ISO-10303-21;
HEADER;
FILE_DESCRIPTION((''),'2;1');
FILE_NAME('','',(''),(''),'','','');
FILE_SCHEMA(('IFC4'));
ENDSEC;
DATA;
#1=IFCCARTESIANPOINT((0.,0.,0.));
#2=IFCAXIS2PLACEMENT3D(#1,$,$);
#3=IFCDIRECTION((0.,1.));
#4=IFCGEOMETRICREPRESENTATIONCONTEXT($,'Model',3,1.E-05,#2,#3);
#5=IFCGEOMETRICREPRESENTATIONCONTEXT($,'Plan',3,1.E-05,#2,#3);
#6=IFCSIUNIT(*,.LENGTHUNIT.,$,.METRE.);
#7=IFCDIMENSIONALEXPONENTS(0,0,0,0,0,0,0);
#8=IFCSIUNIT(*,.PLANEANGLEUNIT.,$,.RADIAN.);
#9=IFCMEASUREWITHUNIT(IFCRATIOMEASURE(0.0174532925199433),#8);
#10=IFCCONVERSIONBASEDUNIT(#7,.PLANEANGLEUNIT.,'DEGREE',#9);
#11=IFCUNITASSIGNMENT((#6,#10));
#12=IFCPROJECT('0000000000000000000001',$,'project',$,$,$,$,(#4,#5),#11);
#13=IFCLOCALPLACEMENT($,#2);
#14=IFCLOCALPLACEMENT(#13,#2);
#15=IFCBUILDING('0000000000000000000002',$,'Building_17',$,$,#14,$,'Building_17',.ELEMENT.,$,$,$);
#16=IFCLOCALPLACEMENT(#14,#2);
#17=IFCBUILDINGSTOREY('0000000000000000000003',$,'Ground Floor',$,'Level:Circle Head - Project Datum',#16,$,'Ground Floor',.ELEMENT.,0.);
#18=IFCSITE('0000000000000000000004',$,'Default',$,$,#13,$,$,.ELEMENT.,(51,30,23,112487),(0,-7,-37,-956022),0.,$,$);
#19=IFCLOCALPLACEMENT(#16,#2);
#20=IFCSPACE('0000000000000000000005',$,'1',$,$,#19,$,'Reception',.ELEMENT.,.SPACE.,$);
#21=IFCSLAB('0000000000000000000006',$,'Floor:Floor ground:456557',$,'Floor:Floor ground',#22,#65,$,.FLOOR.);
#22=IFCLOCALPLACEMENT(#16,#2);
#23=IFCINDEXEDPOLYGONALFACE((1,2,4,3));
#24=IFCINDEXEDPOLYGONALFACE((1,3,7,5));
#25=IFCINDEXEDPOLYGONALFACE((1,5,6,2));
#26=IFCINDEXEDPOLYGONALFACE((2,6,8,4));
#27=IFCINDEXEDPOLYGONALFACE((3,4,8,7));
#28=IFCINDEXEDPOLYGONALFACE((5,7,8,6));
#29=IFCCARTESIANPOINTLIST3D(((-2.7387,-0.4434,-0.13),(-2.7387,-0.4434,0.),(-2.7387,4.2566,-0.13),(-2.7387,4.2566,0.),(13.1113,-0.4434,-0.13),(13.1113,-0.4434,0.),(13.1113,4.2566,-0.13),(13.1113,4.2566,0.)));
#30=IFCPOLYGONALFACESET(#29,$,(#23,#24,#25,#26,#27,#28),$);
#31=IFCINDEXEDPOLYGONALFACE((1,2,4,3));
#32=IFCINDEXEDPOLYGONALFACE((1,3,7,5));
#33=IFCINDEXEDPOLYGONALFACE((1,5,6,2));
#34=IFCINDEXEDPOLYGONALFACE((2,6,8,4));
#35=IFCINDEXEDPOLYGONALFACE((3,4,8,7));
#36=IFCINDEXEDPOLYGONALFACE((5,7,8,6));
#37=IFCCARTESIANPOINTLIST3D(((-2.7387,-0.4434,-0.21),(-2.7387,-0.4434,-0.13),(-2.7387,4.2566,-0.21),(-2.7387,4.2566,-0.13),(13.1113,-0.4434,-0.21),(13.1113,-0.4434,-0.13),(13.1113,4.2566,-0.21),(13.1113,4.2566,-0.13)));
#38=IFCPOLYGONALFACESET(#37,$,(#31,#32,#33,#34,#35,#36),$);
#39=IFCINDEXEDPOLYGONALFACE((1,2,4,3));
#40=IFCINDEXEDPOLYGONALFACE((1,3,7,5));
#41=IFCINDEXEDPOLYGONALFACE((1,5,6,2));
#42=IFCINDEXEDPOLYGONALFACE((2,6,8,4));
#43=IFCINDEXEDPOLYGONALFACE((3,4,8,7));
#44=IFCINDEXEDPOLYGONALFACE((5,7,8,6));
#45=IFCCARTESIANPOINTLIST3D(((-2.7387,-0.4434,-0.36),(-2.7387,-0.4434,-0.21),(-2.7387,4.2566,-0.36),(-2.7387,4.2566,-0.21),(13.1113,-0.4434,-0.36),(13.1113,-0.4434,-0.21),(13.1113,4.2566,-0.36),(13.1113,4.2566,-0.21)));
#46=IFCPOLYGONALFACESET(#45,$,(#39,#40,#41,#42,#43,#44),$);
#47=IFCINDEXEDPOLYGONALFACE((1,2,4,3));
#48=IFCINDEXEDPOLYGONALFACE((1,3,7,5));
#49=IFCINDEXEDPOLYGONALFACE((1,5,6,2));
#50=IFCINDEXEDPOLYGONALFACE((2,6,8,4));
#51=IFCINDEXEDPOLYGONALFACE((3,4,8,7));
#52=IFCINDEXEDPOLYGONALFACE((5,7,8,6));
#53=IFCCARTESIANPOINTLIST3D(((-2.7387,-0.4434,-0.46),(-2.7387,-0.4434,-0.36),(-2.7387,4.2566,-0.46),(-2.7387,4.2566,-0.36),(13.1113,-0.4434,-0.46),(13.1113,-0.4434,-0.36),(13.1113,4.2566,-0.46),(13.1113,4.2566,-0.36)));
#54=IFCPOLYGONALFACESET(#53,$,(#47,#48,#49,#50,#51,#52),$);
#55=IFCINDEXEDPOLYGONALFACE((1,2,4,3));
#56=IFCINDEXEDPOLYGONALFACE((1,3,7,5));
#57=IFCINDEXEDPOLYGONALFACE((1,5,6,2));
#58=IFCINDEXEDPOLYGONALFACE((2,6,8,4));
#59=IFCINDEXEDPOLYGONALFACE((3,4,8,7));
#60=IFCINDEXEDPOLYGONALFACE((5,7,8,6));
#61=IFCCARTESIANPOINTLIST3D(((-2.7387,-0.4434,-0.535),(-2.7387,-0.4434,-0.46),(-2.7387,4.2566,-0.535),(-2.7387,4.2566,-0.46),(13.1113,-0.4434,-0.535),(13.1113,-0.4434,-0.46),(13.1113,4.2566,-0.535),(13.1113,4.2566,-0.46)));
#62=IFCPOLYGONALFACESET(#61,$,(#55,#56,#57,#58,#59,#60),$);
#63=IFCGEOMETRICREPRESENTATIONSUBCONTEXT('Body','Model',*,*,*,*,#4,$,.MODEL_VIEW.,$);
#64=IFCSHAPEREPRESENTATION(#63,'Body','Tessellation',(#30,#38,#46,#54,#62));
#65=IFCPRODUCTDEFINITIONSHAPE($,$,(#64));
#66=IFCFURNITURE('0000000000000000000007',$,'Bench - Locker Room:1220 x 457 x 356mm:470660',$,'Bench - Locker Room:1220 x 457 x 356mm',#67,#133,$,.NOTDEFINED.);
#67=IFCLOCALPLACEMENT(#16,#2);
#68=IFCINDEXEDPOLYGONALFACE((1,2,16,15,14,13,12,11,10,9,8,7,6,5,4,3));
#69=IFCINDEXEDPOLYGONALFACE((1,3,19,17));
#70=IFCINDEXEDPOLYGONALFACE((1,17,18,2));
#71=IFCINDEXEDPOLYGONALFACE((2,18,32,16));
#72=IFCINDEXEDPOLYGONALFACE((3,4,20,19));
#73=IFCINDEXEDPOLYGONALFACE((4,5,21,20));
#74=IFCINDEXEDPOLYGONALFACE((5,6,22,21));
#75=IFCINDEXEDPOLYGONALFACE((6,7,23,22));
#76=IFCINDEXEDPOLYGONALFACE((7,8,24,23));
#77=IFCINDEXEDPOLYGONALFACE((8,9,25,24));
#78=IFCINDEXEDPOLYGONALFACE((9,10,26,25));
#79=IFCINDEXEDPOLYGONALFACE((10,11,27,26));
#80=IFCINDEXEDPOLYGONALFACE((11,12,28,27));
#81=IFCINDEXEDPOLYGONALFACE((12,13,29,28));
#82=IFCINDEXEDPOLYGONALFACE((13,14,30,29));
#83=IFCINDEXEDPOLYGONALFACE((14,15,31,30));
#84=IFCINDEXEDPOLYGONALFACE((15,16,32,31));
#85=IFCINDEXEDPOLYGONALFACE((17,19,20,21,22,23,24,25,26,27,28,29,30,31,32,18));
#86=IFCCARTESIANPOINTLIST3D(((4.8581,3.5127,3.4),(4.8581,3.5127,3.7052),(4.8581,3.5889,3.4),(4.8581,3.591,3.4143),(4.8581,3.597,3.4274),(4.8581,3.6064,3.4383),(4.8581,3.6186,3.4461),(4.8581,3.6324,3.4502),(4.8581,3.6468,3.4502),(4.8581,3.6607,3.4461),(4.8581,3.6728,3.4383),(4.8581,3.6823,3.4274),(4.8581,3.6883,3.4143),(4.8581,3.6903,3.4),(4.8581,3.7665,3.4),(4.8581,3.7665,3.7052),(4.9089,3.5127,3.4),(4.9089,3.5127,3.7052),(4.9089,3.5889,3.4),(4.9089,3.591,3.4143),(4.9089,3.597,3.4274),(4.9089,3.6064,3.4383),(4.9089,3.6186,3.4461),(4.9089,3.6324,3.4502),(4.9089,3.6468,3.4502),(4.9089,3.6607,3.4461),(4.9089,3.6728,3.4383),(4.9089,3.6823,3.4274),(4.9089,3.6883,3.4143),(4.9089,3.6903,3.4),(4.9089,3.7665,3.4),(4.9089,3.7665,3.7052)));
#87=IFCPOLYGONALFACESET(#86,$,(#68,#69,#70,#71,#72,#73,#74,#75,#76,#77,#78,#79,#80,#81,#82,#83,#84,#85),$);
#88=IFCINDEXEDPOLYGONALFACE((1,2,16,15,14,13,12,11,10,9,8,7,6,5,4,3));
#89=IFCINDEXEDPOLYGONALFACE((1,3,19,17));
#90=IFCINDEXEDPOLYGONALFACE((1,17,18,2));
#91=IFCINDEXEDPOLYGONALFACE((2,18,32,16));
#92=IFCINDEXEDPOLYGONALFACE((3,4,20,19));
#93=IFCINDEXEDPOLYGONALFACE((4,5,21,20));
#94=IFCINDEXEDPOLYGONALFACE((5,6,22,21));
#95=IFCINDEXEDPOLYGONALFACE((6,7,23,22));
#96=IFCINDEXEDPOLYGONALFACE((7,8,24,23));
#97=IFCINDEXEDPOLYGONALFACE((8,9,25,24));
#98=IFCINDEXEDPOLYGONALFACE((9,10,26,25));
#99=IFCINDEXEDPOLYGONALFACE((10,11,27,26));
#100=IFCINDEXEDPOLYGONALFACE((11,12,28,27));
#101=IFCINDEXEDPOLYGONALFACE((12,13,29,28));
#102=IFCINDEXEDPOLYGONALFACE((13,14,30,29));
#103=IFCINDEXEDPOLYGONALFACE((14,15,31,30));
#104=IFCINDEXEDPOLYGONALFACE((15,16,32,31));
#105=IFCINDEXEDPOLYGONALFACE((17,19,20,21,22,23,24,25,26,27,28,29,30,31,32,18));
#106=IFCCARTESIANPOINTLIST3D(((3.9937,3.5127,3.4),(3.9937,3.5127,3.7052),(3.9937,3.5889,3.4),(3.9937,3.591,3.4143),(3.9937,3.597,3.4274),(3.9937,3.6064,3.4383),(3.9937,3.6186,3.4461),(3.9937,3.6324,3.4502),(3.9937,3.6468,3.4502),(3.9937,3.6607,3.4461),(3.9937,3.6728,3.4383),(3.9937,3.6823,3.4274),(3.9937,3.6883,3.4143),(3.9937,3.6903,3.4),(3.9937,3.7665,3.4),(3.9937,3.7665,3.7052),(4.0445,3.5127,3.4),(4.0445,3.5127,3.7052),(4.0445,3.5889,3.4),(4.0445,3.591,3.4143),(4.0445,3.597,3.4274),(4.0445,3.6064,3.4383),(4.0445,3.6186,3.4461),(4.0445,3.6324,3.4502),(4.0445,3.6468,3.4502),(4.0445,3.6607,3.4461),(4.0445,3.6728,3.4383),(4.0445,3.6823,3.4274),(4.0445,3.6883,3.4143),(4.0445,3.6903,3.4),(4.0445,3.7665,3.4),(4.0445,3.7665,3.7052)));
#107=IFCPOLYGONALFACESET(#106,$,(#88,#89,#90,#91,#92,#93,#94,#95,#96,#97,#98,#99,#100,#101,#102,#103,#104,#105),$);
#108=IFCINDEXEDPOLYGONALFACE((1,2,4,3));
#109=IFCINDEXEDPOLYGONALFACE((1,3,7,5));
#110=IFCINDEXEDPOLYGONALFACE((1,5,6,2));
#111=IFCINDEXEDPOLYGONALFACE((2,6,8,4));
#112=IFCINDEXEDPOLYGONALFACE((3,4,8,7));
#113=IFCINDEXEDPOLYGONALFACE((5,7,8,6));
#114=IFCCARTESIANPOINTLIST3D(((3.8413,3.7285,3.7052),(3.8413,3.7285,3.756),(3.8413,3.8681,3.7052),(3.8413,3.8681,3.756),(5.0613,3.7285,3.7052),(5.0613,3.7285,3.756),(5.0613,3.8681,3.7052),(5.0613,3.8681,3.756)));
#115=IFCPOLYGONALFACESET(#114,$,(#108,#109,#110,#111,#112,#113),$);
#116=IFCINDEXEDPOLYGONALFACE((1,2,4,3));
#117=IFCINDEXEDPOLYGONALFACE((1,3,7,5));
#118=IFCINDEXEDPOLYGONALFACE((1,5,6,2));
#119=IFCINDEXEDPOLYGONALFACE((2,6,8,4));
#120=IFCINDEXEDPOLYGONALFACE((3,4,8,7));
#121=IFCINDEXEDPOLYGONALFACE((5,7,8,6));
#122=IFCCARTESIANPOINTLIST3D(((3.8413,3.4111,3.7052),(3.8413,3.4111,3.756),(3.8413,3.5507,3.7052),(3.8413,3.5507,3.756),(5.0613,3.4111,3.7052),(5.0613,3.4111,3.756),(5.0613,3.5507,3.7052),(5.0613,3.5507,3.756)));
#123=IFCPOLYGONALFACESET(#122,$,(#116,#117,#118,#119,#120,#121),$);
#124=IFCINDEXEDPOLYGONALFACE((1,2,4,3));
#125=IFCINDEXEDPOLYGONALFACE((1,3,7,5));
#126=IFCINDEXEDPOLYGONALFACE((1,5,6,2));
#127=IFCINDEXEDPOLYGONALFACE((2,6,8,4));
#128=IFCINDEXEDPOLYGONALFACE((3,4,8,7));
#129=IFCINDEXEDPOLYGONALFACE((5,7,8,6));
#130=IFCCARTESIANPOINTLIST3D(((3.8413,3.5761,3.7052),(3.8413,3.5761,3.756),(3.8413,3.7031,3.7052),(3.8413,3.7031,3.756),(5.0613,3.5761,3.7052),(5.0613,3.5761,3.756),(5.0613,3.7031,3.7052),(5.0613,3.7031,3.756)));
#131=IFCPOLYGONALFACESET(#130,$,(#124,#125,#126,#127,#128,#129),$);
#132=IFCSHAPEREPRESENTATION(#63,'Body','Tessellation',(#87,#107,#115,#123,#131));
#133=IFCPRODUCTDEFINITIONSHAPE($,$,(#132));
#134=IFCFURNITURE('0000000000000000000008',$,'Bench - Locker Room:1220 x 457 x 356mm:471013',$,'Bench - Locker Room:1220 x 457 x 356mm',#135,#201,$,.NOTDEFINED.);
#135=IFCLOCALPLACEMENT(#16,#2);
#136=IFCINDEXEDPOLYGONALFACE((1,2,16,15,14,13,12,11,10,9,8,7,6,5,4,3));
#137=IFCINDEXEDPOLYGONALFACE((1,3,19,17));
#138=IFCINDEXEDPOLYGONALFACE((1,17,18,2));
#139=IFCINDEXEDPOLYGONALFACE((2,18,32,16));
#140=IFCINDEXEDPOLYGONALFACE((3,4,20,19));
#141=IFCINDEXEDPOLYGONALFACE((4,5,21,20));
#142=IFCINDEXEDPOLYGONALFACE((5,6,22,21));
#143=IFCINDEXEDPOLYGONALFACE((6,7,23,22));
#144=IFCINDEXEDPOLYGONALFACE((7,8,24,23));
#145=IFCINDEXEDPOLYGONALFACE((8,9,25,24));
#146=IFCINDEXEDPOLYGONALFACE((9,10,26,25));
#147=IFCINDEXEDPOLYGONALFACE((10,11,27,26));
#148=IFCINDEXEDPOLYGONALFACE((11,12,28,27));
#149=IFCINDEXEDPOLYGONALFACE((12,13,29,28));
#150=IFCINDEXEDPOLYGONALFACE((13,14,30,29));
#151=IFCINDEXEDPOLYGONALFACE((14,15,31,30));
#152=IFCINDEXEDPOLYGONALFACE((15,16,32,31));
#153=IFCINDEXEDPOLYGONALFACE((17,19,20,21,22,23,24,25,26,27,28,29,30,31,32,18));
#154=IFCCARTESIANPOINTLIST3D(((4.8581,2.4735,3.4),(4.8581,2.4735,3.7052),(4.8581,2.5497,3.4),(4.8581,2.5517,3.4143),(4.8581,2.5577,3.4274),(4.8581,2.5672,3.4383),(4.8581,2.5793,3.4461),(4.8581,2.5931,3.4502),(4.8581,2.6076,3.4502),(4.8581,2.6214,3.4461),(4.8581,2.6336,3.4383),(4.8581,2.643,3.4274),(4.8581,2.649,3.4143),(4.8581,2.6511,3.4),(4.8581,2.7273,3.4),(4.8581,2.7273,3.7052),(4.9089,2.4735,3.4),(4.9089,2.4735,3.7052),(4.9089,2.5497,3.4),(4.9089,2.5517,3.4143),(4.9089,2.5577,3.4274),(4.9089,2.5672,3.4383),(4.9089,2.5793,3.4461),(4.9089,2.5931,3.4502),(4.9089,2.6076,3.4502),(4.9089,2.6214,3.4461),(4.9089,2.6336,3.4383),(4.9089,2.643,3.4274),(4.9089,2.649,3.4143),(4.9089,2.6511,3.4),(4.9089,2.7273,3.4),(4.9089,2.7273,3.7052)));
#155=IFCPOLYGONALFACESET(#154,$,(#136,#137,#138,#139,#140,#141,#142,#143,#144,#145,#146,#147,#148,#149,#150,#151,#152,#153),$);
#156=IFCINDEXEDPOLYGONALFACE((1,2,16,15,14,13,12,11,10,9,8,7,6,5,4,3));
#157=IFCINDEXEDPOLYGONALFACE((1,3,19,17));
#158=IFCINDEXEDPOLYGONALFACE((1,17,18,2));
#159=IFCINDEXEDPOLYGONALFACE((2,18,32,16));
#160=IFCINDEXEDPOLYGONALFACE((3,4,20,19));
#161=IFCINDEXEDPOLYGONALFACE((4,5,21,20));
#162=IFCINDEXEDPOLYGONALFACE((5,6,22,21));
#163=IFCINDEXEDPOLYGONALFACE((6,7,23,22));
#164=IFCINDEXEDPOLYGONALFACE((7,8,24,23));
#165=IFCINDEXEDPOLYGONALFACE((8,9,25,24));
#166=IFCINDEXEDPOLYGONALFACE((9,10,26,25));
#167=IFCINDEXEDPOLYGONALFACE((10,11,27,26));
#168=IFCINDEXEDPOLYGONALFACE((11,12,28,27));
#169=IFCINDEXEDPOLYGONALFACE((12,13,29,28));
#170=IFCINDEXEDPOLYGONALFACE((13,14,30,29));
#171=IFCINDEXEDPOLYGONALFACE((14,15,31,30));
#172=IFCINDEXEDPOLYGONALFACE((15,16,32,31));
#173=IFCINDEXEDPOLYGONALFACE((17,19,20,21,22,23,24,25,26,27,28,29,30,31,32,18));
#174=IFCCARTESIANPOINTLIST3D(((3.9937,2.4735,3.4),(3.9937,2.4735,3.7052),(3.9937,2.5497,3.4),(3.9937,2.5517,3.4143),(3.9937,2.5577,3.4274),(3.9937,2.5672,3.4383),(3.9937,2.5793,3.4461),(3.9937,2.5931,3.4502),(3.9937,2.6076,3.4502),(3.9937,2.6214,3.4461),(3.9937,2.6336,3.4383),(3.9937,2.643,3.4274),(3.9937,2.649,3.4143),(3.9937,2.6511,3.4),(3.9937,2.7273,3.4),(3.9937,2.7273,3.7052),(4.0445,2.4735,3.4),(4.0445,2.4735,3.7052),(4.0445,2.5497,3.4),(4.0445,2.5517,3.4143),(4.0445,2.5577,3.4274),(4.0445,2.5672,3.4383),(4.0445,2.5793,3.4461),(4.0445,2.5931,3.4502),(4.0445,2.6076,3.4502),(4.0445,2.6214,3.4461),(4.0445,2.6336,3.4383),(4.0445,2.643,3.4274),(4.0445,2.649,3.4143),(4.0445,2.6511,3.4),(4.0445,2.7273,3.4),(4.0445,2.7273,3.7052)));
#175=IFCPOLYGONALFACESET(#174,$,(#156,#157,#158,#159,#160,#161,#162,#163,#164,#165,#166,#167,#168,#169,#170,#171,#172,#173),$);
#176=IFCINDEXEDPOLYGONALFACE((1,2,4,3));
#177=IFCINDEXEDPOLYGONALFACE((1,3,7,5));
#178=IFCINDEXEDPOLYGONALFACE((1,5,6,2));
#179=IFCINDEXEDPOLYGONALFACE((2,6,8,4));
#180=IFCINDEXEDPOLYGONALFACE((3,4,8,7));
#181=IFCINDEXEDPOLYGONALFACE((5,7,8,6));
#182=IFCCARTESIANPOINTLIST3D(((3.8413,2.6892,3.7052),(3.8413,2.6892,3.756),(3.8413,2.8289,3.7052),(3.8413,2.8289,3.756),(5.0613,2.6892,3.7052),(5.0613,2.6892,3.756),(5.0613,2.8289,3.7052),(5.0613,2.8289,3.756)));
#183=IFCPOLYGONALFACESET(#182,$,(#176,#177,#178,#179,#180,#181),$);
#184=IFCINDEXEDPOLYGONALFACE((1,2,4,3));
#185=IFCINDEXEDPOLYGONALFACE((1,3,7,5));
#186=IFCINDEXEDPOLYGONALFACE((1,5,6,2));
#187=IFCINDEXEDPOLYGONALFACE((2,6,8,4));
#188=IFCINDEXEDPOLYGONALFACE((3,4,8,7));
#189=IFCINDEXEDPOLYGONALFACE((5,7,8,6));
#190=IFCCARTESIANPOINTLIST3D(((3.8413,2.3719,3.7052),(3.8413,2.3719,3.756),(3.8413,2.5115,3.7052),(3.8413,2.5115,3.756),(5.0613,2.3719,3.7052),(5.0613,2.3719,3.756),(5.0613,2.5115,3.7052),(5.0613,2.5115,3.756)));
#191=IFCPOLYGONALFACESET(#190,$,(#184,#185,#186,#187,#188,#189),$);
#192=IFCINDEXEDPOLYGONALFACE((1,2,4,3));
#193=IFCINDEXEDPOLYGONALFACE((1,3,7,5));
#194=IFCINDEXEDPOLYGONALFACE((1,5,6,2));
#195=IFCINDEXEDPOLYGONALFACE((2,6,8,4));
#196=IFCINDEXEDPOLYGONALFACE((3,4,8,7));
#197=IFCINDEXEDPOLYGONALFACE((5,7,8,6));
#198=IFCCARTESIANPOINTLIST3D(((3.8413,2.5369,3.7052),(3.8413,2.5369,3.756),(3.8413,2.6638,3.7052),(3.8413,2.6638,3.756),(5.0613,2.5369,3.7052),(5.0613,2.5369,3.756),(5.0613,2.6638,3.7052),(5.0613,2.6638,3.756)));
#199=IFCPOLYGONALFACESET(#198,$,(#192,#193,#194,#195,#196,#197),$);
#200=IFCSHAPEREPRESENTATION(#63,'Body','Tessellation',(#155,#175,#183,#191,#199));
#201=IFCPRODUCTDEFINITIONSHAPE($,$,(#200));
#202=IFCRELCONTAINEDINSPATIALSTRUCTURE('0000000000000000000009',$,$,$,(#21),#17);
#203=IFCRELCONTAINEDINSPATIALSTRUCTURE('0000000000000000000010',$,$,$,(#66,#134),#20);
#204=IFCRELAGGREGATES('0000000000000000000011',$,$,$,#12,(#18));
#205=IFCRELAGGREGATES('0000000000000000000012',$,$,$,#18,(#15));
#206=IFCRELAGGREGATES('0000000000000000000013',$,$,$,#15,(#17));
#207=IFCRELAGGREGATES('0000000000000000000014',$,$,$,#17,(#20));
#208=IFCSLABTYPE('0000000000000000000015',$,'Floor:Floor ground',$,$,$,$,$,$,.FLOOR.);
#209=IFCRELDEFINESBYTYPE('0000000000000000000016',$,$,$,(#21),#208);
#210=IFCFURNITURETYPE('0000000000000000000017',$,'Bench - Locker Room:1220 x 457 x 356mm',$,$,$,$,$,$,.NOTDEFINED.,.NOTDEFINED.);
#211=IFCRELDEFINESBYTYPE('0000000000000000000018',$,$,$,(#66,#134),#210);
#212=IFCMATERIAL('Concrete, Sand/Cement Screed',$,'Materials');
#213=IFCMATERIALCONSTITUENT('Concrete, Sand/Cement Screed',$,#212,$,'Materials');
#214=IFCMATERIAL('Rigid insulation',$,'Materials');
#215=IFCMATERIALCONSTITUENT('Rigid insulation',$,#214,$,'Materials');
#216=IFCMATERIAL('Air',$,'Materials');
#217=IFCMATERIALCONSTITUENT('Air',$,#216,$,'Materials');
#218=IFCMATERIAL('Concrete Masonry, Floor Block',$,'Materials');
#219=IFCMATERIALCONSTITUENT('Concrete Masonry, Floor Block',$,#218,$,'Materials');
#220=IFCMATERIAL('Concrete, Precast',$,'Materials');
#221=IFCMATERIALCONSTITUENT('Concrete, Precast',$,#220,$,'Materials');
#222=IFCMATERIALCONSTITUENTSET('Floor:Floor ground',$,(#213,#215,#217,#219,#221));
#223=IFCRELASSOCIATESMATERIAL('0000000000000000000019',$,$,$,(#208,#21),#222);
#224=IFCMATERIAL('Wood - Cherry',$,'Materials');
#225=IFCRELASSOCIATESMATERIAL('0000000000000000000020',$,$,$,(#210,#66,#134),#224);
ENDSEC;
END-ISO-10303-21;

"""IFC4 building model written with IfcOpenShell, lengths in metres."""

from ifc_helpers import new_model, entity, si_unit, converted_unit, direction, frame, origin, place, context, subcontext, project, spatial, line, arc, indexed_curve, outline, extrude, source, transform, mapped, material, constituent, constituent_set, type_object, type_shapes, element, save


model = new_model("IFC4")

# Units and contexts
model_context = context("Model", 3, precision=1e-05, world=origin(), true_north=direction((0.0, 1.0)))
plan_context = context("Plan", 3, precision=1e-05, world=origin(), true_north=direction((0.0, 1.0)))
body_context = subcontext(model_context, "Body", "Model", "MODEL_VIEW")
ifc_project = project(units=[si_unit("LENGTHUNIT", "METRE"), converted_unit("PLANEANGLEUNIT", "DEGREE", entity("IfcRatioMeasure", 0.0174532925199433), si_unit("PLANEANGLEUNIT", "RADIAN"), dimensions=[0, 0, 0, 0, 0, 0, 0])], contexts=[model_context, plan_context])

# Site, building, storey
site_placement = place(None, origin())
site = spatial("IfcSite", under=ifc_project, at=site_placement, Name="Default", CompositionType="ELEMENT", RefLatitude=(51, 30, 23, 112487), RefLongitude=(0, -7, -37, -956022), RefElevation=0.0)
building_placement = place(site_placement, origin())
building = spatial("IfcBuilding", under=site, at=building_placement, Name="Building_17", LongName="Building_17", CompositionType="ELEMENT")
storey_placement = place(building_placement, origin())
storey = spatial("IfcBuildingStorey", under=building, at=storey_placement, Name="Ground Floor", ObjectType="Level:Circle Head - Project Datum", LongName="Ground Floor", CompositionType="ELEMENT", Elevation=0.0)

# Slab
ifc_material_1 = material(Name="Concrete, Sand/Cement Screed", Category="Materials")
ifc_constituent_1 = constituent(ifc_material_1, Name="Concrete, Sand/Cement Screed", Category="Materials")
ifc_material_2 = material(Name="Rigid insulation", Category="Materials")
ifc_constituent_2 = constituent(ifc_material_2, Name="Rigid insulation", Category="Materials")
ifc_material_3 = material(Name="Air", Category="Materials")
ifc_constituent_3 = constituent(ifc_material_3, Name="Air", Category="Materials")
ifc_material_4 = material(Name="Concrete Masonry, Floor Block", Category="Materials")
ifc_constituent_4 = constituent(ifc_material_4, Name="Concrete Masonry, Floor Block", Category="Materials")
ifc_material_5 = material(Name="Concrete, Precast", Category="Materials")
ifc_constituent_5 = constituent(ifc_material_5, Name="Concrete, Precast", Category="Materials")
ifc_constituent_set = constituent_set(constituents=[ifc_constituent_1, ifc_constituent_2, ifc_constituent_3, ifc_constituent_4, ifc_constituent_5], Name="Floor:Floor ground")
slab_type = type_object("IfcSlabType", Name="Floor:Floor ground", PredefinedType="FLOOR", material=ifc_constituent_set)
slab_placement = place(storey_placement, origin())
element("IfcSlab", 1, at=slab_placement, inside=storey, type_object=slab_type, material=ifc_constituent_set, Name="Floor:Floor ground:456557", ObjectType="Floor:Floor ground", PredefinedType="FLOOR", context=body_context, shape_type="SweptSolid", body=[
    extrude(outline(indexed_curve([(-7.925, -2.35), (7.925, -2.35), (7.925, 2.35), (-7.925, 2.35), (-7.925, -2.35)], self_intersect=False)), frame((5.1863, 1.9066, -0.13), z_axis=(0.0, 0.0, 1.0), x_axis=(-1.0, 0.0, 0.0)), (0.0, 0.0, 1.0), 0.13),
    extrude(outline(indexed_curve([(-7.925, -2.35), (7.925, -2.35), (7.925, 2.35), (-7.925, 2.35), (-7.925, -2.35)], self_intersect=False)), frame((5.1863, 1.9066, -0.21), z_axis=(0.0, 0.0, 1.0), x_axis=(-1.0, 0.0, 0.0)), (0.0, 0.0, 1.0), 0.08),
    extrude(outline(indexed_curve([(-7.925, -2.35), (7.925, -2.35), (7.925, 2.35), (-7.925, 2.35), (-7.925, -2.35)], self_intersect=False)), frame((5.1863, 1.9066, -0.36), z_axis=(0.0, 0.0, 1.0), x_axis=(-1.0, 0.0, 0.0)), (0.0, 0.0, 1.0), 0.15),
    extrude(outline(indexed_curve([(-7.925, -2.35), (7.925, -2.35), (7.925, 2.35), (-7.925, 2.35), (-7.925, -2.35)], self_intersect=False)), frame((5.1863, 1.9066, -0.46), z_axis=(0.0, 0.0, 1.0), x_axis=(-1.0, 0.0, 0.0)), (0.0, 0.0, 1.0), 0.1),
    extrude(outline(indexed_curve([(-7.925, -2.35), (7.925, -2.35), (7.925, 2.35), (-7.925, 2.35), (-7.925, -2.35)], self_intersect=False)), frame((5.1863, 1.9066, -0.535), z_axis=(0.0, 0.0, 1.0), x_axis=(-1.0, 0.0, 0.0)), (0.0, 0.0, 1.0), 0.075),
])

# Shared definitions
space_placement = place(storey_placement, origin())
space = spatial("IfcSpace", under=storey, at=space_placement, Name="1", LongName="Reception", CompositionType="ELEMENT", PredefinedType="SPACE")

# Furniture
ifc_material_6 = material(Name="Wood - Cherry", Category="Materials")
furniture_type = type_object("IfcFurnitureType", Name="Bench - Locker Room:1220 x 457 x 356mm", AssemblyPlace="NOTDEFINED", PredefinedType="NOTDEFINED", material=ifc_material_6)
shared_shape_1 = source(origin(), body_context, "Body", "SweptSolid", [
    extrude(outline(indexed_curve([(-0.1269, 0.1017), (-0.1269, -0.2035), (0.1269, -0.2035), (0.1269, 0.1017), (0.0507, 0.1017), (0.0, 0.051), (-0.0507, 0.1017)], segments=[line(1, 2, 3, 4, 5), arc(5, 6, 7), line(7, 1)], self_intersect=False)), frame((0.2515, -0.1807, 0.1017), z_axis=(-1.0, 0.0, 0.0), x_axis=(0.0, 1.0, 0.0)), (0.0, 0.0, -1.0), 0.0508),
    extrude(outline(indexed_curve([(-0.1017, -0.1269), (0.2035, -0.1269), (0.2035, 0.1269), (-0.1017, 0.1269), (-0.1017, 0.0507), (-0.051, 0.0), (-0.1017, -0.0507)], segments=[line(1, 2, 3, 4, 5), arc(5, 6, 7), line(7, 1)], self_intersect=False)), frame((-0.6129, -0.1807, 0.1017), z_axis=(1.0, 0.0, 0.0), x_axis=(0.0, 0.0, 1.0)), (0.0, 0.0, 1.0), 0.0508),
    extrude(outline(indexed_curve([(-0.61, -0.0698), (0.61, -0.0698), (0.61, 0.0698), (-0.61, 0.0698), (-0.61, -0.0698)], self_intersect=False)), frame((-0.1553, -0.022, 0.3052), z_axis=(0.0, 0.0, 1.0), x_axis=(-1.0, 0.0, 0.0)), (0.0, 0.0, 1.0), 0.0508),
    extrude(outline(indexed_curve([(-0.0698, -0.61), (0.0698, -0.61), (0.0698, 0.61), (-0.0698, 0.61), (-0.0698, -0.61)], self_intersect=False)), frame((-0.1553, -0.3394, 0.3052), z_axis=(0.0, 0.0, 1.0), x_axis=(0.0, 1.0, 0.0)), (0.0, 0.0, 1.0), 0.0508),
    extrude(outline(indexed_curve([(-0.61, -0.0635), (0.61, -0.0635), (0.61, 0.0635), (-0.61, 0.0635), (-0.61, -0.0635)], self_intersect=False)), frame((-0.1553, -0.1807, 0.3052), z_axis=(0.0, 0.0, 1.0), x_axis=(-1.0, 0.0, 0.0)), (0.0, 0.0, 1.0), 0.0508),
])
type_shapes(furniture_type, [shared_shape_1])
for number, where, name in (
    (2, (4.6066, 3.8203, 3.4), "Bench - Locker Room:1220 x 457 x 356mm:470660"),
    (3, (4.6066, 2.7811, 3.4), "Bench - Locker Room:1220 x 457 x 356mm:471013"),
):
    element("IfcFurniture", number, at=place(space_placement, frame(where)), inside=space, type_object=furniture_type, material=ifc_material_6, Name=name, ObjectType="Bench - Locker Room:1220 x 457 x 356mm", PredefinedType="NOTDEFINED", context=body_context, shape_type="MappedRepresentation", body=[
        mapped(shared_shape_1, transform((0.0, 0.0, 0.0), scale=1.0)),
    ])

save(model, "model.ifc")
